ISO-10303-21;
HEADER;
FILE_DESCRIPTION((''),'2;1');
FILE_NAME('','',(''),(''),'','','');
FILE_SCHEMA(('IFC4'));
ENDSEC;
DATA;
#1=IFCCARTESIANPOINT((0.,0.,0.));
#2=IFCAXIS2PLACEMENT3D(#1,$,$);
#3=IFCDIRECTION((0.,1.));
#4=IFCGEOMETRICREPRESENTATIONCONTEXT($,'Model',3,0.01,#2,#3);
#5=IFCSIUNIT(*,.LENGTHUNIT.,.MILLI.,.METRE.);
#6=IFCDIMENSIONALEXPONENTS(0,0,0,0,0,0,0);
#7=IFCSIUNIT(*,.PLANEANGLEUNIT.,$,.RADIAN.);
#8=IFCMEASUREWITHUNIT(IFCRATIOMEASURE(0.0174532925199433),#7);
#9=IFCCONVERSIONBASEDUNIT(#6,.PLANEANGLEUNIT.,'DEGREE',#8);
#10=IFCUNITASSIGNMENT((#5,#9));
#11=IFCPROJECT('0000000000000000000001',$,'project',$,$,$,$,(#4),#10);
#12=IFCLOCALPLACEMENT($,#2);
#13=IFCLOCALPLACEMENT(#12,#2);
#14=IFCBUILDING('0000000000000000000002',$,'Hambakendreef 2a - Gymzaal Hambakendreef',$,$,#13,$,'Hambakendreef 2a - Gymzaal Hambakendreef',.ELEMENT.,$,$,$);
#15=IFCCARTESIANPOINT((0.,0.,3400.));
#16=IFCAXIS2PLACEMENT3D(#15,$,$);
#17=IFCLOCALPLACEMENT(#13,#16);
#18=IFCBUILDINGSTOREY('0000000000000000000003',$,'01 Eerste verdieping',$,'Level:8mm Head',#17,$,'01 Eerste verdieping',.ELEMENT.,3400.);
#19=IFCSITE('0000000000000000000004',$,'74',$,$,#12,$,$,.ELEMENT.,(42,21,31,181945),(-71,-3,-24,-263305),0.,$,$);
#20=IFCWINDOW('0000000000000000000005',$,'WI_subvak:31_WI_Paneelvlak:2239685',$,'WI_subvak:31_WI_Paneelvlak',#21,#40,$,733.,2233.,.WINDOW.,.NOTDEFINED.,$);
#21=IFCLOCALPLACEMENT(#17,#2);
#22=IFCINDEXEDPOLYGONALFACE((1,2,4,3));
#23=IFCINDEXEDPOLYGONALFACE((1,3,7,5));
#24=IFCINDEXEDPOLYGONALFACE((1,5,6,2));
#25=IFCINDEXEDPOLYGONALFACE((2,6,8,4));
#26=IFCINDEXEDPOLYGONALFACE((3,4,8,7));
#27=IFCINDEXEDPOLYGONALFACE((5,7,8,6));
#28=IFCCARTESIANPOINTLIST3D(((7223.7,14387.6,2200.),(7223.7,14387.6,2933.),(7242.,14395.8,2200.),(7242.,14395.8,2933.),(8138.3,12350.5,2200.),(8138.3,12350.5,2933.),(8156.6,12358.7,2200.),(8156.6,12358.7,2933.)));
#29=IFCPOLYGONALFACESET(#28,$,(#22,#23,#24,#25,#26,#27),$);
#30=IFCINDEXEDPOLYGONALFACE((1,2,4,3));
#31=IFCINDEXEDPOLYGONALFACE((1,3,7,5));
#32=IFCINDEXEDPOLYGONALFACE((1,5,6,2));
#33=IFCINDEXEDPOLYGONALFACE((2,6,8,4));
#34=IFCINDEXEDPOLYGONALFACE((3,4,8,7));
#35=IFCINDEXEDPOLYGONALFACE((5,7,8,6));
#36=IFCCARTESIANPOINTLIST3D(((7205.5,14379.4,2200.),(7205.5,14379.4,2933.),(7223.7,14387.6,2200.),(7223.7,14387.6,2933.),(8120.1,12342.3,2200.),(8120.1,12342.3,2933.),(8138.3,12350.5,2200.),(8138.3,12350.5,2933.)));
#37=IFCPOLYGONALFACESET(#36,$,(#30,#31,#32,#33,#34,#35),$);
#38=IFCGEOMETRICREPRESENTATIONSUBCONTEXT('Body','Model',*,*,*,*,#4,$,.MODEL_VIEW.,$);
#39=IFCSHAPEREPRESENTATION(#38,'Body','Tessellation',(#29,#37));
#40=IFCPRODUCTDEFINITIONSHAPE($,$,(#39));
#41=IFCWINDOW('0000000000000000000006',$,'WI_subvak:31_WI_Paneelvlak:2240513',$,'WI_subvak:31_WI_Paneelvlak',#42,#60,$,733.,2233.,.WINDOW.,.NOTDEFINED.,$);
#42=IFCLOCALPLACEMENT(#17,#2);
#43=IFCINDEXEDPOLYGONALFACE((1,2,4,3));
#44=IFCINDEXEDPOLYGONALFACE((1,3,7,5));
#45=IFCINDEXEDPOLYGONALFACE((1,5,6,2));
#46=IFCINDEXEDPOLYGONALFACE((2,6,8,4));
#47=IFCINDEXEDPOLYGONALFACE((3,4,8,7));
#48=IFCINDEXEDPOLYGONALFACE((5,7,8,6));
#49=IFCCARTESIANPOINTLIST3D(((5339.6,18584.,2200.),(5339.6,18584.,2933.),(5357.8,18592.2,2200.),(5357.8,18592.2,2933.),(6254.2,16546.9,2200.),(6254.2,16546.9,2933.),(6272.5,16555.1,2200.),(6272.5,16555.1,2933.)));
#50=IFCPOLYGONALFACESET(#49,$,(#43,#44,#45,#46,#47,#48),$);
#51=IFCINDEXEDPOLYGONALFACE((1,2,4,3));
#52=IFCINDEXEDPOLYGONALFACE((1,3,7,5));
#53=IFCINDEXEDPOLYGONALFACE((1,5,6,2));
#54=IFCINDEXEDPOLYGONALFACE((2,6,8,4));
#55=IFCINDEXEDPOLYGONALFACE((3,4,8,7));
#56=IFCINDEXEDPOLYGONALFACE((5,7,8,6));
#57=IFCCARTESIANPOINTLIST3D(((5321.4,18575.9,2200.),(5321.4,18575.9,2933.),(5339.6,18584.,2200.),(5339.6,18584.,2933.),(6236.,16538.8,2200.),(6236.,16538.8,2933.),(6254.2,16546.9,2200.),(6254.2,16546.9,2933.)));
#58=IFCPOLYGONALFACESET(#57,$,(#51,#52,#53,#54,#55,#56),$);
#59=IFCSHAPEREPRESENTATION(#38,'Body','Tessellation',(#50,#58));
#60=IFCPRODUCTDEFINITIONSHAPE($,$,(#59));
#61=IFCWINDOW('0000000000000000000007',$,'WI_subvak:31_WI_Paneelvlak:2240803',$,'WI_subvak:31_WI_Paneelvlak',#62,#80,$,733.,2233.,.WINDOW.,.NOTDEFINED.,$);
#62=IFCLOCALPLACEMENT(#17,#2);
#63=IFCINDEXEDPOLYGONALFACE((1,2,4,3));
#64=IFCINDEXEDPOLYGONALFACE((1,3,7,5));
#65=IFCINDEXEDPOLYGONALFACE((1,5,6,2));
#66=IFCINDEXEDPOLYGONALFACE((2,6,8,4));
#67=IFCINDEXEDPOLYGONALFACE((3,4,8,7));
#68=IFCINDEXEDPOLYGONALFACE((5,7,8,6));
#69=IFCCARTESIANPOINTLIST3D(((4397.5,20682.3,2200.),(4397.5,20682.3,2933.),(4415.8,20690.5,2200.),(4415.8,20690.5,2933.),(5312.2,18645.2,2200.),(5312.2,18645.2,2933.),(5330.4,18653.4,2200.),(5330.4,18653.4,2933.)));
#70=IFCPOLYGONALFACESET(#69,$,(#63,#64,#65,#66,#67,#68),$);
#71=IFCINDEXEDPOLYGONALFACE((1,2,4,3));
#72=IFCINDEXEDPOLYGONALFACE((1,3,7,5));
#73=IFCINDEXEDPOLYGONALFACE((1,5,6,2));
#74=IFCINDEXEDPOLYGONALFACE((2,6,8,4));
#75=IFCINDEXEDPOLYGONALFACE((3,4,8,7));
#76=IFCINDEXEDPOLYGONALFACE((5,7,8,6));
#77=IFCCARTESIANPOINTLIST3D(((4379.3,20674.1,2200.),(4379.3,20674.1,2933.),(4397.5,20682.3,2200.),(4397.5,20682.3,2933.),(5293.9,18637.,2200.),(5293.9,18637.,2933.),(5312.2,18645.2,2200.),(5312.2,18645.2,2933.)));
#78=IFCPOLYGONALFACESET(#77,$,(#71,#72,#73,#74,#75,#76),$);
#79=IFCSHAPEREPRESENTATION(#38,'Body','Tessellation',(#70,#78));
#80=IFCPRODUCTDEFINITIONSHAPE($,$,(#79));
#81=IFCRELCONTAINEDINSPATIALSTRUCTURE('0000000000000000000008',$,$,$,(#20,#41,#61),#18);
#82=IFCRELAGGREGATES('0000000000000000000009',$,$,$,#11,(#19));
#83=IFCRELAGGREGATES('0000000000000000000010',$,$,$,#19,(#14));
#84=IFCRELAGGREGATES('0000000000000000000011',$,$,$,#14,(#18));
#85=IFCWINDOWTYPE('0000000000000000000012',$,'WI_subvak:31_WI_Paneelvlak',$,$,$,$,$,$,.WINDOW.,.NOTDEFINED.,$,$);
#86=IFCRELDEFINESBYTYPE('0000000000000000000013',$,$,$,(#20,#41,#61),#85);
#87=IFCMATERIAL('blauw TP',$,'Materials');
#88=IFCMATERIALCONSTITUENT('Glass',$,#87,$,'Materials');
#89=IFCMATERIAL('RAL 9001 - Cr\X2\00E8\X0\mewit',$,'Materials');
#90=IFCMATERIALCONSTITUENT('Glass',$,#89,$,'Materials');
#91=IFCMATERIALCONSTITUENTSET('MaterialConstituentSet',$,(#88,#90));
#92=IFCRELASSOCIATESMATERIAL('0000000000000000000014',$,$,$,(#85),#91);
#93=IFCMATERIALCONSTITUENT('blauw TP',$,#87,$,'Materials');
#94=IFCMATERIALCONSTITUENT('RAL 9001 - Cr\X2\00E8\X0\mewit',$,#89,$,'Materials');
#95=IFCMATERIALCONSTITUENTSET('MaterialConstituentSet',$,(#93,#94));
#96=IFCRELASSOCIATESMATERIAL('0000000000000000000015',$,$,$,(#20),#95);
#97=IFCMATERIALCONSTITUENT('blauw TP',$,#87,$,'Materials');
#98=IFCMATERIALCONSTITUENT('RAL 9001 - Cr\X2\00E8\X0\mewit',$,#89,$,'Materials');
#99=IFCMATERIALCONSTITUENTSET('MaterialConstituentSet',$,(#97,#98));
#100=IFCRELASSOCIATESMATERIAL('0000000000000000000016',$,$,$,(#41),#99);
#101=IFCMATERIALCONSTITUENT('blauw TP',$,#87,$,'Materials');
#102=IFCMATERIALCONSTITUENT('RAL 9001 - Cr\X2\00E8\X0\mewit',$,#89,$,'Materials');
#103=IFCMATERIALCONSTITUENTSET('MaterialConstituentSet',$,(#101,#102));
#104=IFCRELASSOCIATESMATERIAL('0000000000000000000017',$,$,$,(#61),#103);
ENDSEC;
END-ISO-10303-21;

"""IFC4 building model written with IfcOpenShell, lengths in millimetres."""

from ifc_helpers import new_model, entity, si_unit, converted_unit, direction, frame, origin, place, context, subcontext, project, spatial, indexed_curve, outline, extrude, source, transform, mapped, material, constituent, constituent_set, type_object, type_shapes, element, save


model = new_model("IFC4")

# Units and contexts
model_context = context("Model", 3, precision=0.01, world=origin(), true_north=direction((0.0, 1.0)))
body_context = subcontext(model_context, "Body", "Model", "MODEL_VIEW")
ifc_project = project(units=[si_unit("LENGTHUNIT", "METRE", prefix="MILLI"), converted_unit("PLANEANGLEUNIT", "DEGREE", entity("IfcRatioMeasure", 0.0174532925199433), si_unit("PLANEANGLEUNIT", "RADIAN"), dimensions=[0, 0, 0, 0, 0, 0, 0])], contexts=[model_context])

# Site, building, storey
site_placement = place(None, origin())
site = spatial("IfcSite", under=ifc_project, at=site_placement, Name="74", CompositionType="ELEMENT", RefLatitude=(42, 21, 31, 181945), RefLongitude=(-71, -3, -24, -263305), RefElevation=0.0)
building_placement = place(site_placement, origin())
building = spatial("IfcBuilding", under=site, at=building_placement, Name="Hambakendreef 2a - Gymzaal Hambakendreef", LongName="Hambakendreef 2a - Gymzaal Hambakendreef", CompositionType="ELEMENT")
storey_placement = place(building_placement, frame((0.0, 0.0, 3400.0)))
storey = spatial("IfcBuildingStorey", under=building, at=storey_placement, Name="01 Eerste verdieping", ObjectType="Level:8mm Head", LongName="01 Eerste verdieping", CompositionType="ELEMENT", Elevation=3400.0)

# Windows
ifc_material_1 = material(Name="blauw TP", Category="Materials")
ifc_material_2 = material(Name="RAL 9001 - Crèmewit", Category="Materials")
ifc_constituent_1 = constituent(ifc_material_1, Name="Glass", Category="Materials")
ifc_constituent_2 = constituent(ifc_material_2, Name="Glass", Category="Materials")
ifc_constituent_set_1 = constituent_set(constituents=[ifc_constituent_1, ifc_constituent_2], Name="MaterialConstituentSet")
window_type_1 = type_object("IfcWindowType", Name="WI_subvak:31_WI_Paneelvlak", PartitioningType="NOTDEFINED", PredefinedType="WINDOW", material=ifc_constituent_set_1)
shared_shape_1 = source(origin(), body_context, "Body", "SweptSolid", [
    extrude(outline(indexed_curve([(-10.0, -1116.5), (10.0, -1116.5), (10.0, 1116.5), (-10.0, 1116.5), (-10.0, -1116.5)], self_intersect=False)), frame((0.0, 10.0, 0.0), z_axis=(0.0, 0.0, 1.0), x_axis=(0.0, -1.0, 0.0)), (0.0, 0.0, 1.0), 733.0),
    extrude(outline(indexed_curve([(-10.0, -1116.5), (10.0, -1116.5), (10.0, 1116.5), (-10.0, 1116.5), (-10.0, -1116.5)], self_intersect=False)), frame((0.0, -10.0, 0.0), z_axis=(0.0, 0.0, 1.0), x_axis=(0.0, -1.0, 0.0)), (0.0, 0.0, 1.0), 733.0),
])
type_shapes(window_type_1, [shared_shape_1])
ifc_constituent_3 = constituent(ifc_material_1, Name="blauw TP", Category="Materials")
ifc_constituent_4 = constituent(ifc_material_2, Name="RAL 9001 - Crèmewit", Category="Materials")
ifc_constituent_set_2 = constituent_set(constituents=[ifc_constituent_3, ifc_constituent_4], Name="MaterialConstituentSet")
window_1_placement = place(storey_placement, frame((7681.0, 13369.1, 2200.0), z_axis=(0.0, 0.0, 1.0), x_axis=(0.40959, -0.91227, 0.0)))
element("IfcWindow", 1, at=window_1_placement, inside=storey, type_object=window_type_1, material=ifc_constituent_set_2, Name="WI_subvak:31_WI_Paneelvlak:2239685", ObjectType="WI_subvak:31_WI_Paneelvlak", OverallHeight=733.0, OverallWidth=2233.0, PartitioningType="NOTDEFINED", PredefinedType="WINDOW", context=body_context, shape_type="MappedRepresentation", body=[
    mapped(shared_shape_1, transform((0.0, 0.0, 0.0), scale=1.0)),
])
ifc_constituent_5 = constituent(ifc_material_1, Name="blauw TP", Category="Materials")
ifc_constituent_6 = constituent(ifc_material_2, Name="RAL 9001 - Crèmewit", Category="Materials")
ifc_constituent_set_3 = constituent_set(constituents=[ifc_constituent_5, ifc_constituent_6], Name="MaterialConstituentSet")
window_2_placement = place(storey_placement, frame((5796.9, 17565.5, 2200.0), z_axis=(0.0, 0.0, 1.0), x_axis=(0.40959, -0.91227, 0.0)))
element("IfcWindow", 2, at=window_2_placement, inside=storey, type_object=window_type_1, material=ifc_constituent_set_3, Name="WI_subvak:31_WI_Paneelvlak:2240513", ObjectType="WI_subvak:31_WI_Paneelvlak", OverallHeight=733.0, OverallWidth=2233.0, PartitioningType="NOTDEFINED", PredefinedType="WINDOW", context=body_context, shape_type="MappedRepresentation", body=[
    mapped(shared_shape_1, transform((0.0, 0.0, 0.0), scale=1.0)),
])
ifc_constituent_7 = constituent(ifc_material_1, Name="blauw TP", Category="Materials")
ifc_constituent_8 = constituent(ifc_material_2, Name="RAL 9001 - Crèmewit", Category="Materials")
ifc_constituent_set_4 = constituent_set(constituents=[ifc_constituent_7, ifc_constituent_8], Name="MaterialConstituentSet")
window_3_placement = place(storey_placement, frame((4854.8, 19663.7, 2200.0), z_axis=(0.0, 0.0, 1.0), x_axis=(0.40959, -0.91227, 0.0)))
element("IfcWindow", 3, at=window_3_placement, inside=storey, type_object=window_type_1, material=ifc_constituent_set_4, Name="WI_subvak:31_WI_Paneelvlak:2240803", ObjectType="WI_subvak:31_WI_Paneelvlak", OverallHeight=733.0, OverallWidth=2233.0, PartitioningType="NOTDEFINED", PredefinedType="WINDOW", context=body_context, shape_type="MappedRepresentation", body=[
    mapped(shared_shape_1, transform((0.0, 0.0, 0.0), scale=1.0)),
])

save(model, "model.ifc")
